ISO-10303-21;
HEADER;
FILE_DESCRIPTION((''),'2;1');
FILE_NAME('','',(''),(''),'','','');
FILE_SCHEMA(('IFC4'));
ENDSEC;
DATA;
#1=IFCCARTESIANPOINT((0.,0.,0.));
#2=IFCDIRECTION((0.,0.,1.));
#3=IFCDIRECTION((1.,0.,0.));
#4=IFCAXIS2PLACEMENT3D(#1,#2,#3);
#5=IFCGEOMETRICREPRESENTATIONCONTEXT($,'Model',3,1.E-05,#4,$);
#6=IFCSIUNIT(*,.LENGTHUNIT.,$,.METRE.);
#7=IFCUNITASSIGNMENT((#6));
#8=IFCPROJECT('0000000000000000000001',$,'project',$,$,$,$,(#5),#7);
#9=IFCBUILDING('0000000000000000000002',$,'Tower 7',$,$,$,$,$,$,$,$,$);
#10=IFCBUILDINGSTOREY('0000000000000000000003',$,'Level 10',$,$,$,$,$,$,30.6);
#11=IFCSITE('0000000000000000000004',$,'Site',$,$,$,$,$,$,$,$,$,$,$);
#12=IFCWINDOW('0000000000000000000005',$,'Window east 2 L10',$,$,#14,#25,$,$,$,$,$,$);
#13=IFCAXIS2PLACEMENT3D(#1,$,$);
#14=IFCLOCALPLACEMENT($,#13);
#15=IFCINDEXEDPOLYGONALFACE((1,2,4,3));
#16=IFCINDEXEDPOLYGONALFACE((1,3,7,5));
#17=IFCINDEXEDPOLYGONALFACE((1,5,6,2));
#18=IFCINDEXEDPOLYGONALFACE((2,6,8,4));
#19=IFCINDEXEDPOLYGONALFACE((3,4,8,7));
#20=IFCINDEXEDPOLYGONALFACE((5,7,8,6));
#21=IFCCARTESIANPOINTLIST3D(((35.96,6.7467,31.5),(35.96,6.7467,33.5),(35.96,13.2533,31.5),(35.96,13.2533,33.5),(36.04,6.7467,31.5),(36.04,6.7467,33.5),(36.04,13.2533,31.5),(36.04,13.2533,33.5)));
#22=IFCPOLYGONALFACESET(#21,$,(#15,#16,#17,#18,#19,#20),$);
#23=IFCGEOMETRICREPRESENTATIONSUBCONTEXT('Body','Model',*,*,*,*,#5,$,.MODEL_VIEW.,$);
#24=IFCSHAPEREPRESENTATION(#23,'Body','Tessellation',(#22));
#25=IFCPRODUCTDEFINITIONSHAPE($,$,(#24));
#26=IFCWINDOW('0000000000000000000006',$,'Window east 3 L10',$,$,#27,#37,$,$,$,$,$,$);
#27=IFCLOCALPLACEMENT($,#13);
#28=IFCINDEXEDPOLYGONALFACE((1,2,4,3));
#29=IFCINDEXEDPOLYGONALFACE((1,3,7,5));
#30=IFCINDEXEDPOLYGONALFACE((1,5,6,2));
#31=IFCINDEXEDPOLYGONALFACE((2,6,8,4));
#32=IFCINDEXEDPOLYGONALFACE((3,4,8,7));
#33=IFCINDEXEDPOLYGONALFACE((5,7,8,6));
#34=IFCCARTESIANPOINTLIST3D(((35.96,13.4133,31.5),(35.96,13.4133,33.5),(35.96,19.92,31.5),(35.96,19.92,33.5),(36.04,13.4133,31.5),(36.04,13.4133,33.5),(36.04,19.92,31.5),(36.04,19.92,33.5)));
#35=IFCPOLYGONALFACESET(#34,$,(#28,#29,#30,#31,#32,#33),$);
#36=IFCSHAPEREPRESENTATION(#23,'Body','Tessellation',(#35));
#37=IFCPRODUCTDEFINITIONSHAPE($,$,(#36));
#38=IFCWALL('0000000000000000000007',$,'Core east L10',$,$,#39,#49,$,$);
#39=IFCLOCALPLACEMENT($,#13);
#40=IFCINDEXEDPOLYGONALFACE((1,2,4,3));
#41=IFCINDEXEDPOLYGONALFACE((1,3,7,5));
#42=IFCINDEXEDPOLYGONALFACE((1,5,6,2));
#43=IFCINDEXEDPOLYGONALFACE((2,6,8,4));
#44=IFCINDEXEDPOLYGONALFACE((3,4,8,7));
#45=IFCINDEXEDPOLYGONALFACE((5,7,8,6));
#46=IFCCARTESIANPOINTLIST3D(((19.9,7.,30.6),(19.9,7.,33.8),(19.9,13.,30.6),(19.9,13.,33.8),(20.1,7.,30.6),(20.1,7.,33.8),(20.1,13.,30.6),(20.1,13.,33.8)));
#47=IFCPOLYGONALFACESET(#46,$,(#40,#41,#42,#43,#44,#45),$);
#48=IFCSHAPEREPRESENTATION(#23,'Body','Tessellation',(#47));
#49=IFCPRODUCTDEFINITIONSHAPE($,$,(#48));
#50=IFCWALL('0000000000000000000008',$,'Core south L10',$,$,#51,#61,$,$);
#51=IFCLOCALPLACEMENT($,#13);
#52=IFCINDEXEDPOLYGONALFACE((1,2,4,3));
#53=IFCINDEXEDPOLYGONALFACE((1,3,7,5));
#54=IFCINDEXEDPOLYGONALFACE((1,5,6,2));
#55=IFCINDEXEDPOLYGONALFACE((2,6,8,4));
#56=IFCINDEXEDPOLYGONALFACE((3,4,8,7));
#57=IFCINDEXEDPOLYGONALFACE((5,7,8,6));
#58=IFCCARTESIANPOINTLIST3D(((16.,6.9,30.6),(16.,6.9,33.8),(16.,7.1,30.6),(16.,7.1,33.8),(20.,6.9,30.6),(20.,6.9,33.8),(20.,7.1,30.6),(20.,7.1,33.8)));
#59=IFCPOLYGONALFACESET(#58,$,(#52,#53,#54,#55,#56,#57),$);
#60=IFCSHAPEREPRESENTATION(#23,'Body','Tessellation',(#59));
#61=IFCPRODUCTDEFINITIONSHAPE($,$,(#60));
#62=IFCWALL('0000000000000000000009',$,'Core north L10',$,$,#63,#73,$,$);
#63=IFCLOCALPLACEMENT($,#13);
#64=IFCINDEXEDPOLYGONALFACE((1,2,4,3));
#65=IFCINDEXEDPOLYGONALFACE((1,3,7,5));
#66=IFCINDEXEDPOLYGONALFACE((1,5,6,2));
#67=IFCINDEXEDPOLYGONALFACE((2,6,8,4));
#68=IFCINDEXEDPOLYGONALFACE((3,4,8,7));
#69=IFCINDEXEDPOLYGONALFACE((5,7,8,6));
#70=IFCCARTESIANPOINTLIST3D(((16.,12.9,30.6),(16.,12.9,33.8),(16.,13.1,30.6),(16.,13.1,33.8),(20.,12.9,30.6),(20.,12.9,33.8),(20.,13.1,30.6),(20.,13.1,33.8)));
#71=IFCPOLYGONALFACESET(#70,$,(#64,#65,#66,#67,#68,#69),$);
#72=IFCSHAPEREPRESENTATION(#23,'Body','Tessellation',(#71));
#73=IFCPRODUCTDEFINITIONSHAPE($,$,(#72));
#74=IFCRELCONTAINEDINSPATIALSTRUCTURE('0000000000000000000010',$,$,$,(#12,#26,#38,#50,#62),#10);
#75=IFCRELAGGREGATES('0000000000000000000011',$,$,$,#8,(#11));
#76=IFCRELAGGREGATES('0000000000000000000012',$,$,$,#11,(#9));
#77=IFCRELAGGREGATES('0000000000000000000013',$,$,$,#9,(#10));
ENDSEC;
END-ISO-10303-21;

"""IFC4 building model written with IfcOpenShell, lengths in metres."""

from ifc_helpers import new_model, si_unit, frame, origin, origin_with_axes, origin_2d, place, context, subcontext, project, spatial, rectangle, extrude, element, save


model = new_model("IFC4")

# Units and contexts
model_context = context("Model", 3, precision=1e-05, world=origin_with_axes())
body_context = subcontext(model_context, "Body", "Model", "MODEL_VIEW")
ifc_project = project(units=[si_unit("LENGTHUNIT", "METRE")], contexts=[model_context])

# Site, building, storey
site = spatial("IfcSite", under=ifc_project, Name="Site")
building = spatial("IfcBuilding", under=site, Name="Tower 7")
storey = spatial("IfcBuildingStorey", under=building, Name="Level 10", Elevation=30.6)

# Windows
for number, where, z_axis, x_axis, name in (
    (1, (36.0, 10.0, 31.5), (0.0, 0.0, 1.0), (1.0, 0.0, 0.0), "Window east 2 L10"),
):
    element("IfcWindow", number, at=place(None, frame(where, z_axis=z_axis, x_axis=x_axis)), inside=storey, Name=name, context=body_context, shape_type="SweptSolid", body=[
        extrude(rectangle(XDim=0.08, YDim=6.5067, at=origin_2d()), origin(), (0.0, 0.0, 1.0), 2.0),
    ])
window_placement = place(None, frame((36.0, 16.6667, 31.5), z_axis=(0.0, 0.0, 1.0), x_axis=(1.0, 0.0, 0.0)))
element("IfcWindow", 2, at=window_placement, inside=storey, Name="Window east 3 L10", context=body_context, shape_type="SweptSolid", body=[
    extrude(rectangle(XDim=0.08, YDim=6.5067, at=origin_2d()), origin(), (0.0, 0.0, 1.0), 2.0),
])

# Walls
wall_1_placement = place(None, frame((20.0, 10.0, 30.6), z_axis=(0.0, 0.0, 1.0), x_axis=(1.0, 0.0, 0.0)))
element("IfcWall", 3, at=wall_1_placement, inside=storey, Name="Core east L10", context=body_context, shape_type="SweptSolid", body=[
    extrude(rectangle(XDim=0.2, YDim=6.0, at=origin_2d()), origin(), (0.0, 0.0, 1.0), 3.2),
])
for number, where, z_axis, x_axis, name in (
    (4, (18.0, 7.0, 30.6), (0.0, 0.0, 1.0), (1.0, 0.0, 0.0), "Core south L10"),
    (5, (18.0, 13.0, 30.6), (0.0, 0.0, 1.0), (1.0, 0.0, 0.0), "Core north L10"),
):
    element("IfcWall", number, at=place(None, frame(where, z_axis=z_axis, x_axis=x_axis)), inside=storey, Name=name, context=body_context, shape_type="SweptSolid", body=[
        extrude(rectangle(XDim=4.0, YDim=0.2, at=origin_2d()), origin(), (0.0, 0.0, 1.0), 3.2),
    ])

save(model, "model.ifc")
